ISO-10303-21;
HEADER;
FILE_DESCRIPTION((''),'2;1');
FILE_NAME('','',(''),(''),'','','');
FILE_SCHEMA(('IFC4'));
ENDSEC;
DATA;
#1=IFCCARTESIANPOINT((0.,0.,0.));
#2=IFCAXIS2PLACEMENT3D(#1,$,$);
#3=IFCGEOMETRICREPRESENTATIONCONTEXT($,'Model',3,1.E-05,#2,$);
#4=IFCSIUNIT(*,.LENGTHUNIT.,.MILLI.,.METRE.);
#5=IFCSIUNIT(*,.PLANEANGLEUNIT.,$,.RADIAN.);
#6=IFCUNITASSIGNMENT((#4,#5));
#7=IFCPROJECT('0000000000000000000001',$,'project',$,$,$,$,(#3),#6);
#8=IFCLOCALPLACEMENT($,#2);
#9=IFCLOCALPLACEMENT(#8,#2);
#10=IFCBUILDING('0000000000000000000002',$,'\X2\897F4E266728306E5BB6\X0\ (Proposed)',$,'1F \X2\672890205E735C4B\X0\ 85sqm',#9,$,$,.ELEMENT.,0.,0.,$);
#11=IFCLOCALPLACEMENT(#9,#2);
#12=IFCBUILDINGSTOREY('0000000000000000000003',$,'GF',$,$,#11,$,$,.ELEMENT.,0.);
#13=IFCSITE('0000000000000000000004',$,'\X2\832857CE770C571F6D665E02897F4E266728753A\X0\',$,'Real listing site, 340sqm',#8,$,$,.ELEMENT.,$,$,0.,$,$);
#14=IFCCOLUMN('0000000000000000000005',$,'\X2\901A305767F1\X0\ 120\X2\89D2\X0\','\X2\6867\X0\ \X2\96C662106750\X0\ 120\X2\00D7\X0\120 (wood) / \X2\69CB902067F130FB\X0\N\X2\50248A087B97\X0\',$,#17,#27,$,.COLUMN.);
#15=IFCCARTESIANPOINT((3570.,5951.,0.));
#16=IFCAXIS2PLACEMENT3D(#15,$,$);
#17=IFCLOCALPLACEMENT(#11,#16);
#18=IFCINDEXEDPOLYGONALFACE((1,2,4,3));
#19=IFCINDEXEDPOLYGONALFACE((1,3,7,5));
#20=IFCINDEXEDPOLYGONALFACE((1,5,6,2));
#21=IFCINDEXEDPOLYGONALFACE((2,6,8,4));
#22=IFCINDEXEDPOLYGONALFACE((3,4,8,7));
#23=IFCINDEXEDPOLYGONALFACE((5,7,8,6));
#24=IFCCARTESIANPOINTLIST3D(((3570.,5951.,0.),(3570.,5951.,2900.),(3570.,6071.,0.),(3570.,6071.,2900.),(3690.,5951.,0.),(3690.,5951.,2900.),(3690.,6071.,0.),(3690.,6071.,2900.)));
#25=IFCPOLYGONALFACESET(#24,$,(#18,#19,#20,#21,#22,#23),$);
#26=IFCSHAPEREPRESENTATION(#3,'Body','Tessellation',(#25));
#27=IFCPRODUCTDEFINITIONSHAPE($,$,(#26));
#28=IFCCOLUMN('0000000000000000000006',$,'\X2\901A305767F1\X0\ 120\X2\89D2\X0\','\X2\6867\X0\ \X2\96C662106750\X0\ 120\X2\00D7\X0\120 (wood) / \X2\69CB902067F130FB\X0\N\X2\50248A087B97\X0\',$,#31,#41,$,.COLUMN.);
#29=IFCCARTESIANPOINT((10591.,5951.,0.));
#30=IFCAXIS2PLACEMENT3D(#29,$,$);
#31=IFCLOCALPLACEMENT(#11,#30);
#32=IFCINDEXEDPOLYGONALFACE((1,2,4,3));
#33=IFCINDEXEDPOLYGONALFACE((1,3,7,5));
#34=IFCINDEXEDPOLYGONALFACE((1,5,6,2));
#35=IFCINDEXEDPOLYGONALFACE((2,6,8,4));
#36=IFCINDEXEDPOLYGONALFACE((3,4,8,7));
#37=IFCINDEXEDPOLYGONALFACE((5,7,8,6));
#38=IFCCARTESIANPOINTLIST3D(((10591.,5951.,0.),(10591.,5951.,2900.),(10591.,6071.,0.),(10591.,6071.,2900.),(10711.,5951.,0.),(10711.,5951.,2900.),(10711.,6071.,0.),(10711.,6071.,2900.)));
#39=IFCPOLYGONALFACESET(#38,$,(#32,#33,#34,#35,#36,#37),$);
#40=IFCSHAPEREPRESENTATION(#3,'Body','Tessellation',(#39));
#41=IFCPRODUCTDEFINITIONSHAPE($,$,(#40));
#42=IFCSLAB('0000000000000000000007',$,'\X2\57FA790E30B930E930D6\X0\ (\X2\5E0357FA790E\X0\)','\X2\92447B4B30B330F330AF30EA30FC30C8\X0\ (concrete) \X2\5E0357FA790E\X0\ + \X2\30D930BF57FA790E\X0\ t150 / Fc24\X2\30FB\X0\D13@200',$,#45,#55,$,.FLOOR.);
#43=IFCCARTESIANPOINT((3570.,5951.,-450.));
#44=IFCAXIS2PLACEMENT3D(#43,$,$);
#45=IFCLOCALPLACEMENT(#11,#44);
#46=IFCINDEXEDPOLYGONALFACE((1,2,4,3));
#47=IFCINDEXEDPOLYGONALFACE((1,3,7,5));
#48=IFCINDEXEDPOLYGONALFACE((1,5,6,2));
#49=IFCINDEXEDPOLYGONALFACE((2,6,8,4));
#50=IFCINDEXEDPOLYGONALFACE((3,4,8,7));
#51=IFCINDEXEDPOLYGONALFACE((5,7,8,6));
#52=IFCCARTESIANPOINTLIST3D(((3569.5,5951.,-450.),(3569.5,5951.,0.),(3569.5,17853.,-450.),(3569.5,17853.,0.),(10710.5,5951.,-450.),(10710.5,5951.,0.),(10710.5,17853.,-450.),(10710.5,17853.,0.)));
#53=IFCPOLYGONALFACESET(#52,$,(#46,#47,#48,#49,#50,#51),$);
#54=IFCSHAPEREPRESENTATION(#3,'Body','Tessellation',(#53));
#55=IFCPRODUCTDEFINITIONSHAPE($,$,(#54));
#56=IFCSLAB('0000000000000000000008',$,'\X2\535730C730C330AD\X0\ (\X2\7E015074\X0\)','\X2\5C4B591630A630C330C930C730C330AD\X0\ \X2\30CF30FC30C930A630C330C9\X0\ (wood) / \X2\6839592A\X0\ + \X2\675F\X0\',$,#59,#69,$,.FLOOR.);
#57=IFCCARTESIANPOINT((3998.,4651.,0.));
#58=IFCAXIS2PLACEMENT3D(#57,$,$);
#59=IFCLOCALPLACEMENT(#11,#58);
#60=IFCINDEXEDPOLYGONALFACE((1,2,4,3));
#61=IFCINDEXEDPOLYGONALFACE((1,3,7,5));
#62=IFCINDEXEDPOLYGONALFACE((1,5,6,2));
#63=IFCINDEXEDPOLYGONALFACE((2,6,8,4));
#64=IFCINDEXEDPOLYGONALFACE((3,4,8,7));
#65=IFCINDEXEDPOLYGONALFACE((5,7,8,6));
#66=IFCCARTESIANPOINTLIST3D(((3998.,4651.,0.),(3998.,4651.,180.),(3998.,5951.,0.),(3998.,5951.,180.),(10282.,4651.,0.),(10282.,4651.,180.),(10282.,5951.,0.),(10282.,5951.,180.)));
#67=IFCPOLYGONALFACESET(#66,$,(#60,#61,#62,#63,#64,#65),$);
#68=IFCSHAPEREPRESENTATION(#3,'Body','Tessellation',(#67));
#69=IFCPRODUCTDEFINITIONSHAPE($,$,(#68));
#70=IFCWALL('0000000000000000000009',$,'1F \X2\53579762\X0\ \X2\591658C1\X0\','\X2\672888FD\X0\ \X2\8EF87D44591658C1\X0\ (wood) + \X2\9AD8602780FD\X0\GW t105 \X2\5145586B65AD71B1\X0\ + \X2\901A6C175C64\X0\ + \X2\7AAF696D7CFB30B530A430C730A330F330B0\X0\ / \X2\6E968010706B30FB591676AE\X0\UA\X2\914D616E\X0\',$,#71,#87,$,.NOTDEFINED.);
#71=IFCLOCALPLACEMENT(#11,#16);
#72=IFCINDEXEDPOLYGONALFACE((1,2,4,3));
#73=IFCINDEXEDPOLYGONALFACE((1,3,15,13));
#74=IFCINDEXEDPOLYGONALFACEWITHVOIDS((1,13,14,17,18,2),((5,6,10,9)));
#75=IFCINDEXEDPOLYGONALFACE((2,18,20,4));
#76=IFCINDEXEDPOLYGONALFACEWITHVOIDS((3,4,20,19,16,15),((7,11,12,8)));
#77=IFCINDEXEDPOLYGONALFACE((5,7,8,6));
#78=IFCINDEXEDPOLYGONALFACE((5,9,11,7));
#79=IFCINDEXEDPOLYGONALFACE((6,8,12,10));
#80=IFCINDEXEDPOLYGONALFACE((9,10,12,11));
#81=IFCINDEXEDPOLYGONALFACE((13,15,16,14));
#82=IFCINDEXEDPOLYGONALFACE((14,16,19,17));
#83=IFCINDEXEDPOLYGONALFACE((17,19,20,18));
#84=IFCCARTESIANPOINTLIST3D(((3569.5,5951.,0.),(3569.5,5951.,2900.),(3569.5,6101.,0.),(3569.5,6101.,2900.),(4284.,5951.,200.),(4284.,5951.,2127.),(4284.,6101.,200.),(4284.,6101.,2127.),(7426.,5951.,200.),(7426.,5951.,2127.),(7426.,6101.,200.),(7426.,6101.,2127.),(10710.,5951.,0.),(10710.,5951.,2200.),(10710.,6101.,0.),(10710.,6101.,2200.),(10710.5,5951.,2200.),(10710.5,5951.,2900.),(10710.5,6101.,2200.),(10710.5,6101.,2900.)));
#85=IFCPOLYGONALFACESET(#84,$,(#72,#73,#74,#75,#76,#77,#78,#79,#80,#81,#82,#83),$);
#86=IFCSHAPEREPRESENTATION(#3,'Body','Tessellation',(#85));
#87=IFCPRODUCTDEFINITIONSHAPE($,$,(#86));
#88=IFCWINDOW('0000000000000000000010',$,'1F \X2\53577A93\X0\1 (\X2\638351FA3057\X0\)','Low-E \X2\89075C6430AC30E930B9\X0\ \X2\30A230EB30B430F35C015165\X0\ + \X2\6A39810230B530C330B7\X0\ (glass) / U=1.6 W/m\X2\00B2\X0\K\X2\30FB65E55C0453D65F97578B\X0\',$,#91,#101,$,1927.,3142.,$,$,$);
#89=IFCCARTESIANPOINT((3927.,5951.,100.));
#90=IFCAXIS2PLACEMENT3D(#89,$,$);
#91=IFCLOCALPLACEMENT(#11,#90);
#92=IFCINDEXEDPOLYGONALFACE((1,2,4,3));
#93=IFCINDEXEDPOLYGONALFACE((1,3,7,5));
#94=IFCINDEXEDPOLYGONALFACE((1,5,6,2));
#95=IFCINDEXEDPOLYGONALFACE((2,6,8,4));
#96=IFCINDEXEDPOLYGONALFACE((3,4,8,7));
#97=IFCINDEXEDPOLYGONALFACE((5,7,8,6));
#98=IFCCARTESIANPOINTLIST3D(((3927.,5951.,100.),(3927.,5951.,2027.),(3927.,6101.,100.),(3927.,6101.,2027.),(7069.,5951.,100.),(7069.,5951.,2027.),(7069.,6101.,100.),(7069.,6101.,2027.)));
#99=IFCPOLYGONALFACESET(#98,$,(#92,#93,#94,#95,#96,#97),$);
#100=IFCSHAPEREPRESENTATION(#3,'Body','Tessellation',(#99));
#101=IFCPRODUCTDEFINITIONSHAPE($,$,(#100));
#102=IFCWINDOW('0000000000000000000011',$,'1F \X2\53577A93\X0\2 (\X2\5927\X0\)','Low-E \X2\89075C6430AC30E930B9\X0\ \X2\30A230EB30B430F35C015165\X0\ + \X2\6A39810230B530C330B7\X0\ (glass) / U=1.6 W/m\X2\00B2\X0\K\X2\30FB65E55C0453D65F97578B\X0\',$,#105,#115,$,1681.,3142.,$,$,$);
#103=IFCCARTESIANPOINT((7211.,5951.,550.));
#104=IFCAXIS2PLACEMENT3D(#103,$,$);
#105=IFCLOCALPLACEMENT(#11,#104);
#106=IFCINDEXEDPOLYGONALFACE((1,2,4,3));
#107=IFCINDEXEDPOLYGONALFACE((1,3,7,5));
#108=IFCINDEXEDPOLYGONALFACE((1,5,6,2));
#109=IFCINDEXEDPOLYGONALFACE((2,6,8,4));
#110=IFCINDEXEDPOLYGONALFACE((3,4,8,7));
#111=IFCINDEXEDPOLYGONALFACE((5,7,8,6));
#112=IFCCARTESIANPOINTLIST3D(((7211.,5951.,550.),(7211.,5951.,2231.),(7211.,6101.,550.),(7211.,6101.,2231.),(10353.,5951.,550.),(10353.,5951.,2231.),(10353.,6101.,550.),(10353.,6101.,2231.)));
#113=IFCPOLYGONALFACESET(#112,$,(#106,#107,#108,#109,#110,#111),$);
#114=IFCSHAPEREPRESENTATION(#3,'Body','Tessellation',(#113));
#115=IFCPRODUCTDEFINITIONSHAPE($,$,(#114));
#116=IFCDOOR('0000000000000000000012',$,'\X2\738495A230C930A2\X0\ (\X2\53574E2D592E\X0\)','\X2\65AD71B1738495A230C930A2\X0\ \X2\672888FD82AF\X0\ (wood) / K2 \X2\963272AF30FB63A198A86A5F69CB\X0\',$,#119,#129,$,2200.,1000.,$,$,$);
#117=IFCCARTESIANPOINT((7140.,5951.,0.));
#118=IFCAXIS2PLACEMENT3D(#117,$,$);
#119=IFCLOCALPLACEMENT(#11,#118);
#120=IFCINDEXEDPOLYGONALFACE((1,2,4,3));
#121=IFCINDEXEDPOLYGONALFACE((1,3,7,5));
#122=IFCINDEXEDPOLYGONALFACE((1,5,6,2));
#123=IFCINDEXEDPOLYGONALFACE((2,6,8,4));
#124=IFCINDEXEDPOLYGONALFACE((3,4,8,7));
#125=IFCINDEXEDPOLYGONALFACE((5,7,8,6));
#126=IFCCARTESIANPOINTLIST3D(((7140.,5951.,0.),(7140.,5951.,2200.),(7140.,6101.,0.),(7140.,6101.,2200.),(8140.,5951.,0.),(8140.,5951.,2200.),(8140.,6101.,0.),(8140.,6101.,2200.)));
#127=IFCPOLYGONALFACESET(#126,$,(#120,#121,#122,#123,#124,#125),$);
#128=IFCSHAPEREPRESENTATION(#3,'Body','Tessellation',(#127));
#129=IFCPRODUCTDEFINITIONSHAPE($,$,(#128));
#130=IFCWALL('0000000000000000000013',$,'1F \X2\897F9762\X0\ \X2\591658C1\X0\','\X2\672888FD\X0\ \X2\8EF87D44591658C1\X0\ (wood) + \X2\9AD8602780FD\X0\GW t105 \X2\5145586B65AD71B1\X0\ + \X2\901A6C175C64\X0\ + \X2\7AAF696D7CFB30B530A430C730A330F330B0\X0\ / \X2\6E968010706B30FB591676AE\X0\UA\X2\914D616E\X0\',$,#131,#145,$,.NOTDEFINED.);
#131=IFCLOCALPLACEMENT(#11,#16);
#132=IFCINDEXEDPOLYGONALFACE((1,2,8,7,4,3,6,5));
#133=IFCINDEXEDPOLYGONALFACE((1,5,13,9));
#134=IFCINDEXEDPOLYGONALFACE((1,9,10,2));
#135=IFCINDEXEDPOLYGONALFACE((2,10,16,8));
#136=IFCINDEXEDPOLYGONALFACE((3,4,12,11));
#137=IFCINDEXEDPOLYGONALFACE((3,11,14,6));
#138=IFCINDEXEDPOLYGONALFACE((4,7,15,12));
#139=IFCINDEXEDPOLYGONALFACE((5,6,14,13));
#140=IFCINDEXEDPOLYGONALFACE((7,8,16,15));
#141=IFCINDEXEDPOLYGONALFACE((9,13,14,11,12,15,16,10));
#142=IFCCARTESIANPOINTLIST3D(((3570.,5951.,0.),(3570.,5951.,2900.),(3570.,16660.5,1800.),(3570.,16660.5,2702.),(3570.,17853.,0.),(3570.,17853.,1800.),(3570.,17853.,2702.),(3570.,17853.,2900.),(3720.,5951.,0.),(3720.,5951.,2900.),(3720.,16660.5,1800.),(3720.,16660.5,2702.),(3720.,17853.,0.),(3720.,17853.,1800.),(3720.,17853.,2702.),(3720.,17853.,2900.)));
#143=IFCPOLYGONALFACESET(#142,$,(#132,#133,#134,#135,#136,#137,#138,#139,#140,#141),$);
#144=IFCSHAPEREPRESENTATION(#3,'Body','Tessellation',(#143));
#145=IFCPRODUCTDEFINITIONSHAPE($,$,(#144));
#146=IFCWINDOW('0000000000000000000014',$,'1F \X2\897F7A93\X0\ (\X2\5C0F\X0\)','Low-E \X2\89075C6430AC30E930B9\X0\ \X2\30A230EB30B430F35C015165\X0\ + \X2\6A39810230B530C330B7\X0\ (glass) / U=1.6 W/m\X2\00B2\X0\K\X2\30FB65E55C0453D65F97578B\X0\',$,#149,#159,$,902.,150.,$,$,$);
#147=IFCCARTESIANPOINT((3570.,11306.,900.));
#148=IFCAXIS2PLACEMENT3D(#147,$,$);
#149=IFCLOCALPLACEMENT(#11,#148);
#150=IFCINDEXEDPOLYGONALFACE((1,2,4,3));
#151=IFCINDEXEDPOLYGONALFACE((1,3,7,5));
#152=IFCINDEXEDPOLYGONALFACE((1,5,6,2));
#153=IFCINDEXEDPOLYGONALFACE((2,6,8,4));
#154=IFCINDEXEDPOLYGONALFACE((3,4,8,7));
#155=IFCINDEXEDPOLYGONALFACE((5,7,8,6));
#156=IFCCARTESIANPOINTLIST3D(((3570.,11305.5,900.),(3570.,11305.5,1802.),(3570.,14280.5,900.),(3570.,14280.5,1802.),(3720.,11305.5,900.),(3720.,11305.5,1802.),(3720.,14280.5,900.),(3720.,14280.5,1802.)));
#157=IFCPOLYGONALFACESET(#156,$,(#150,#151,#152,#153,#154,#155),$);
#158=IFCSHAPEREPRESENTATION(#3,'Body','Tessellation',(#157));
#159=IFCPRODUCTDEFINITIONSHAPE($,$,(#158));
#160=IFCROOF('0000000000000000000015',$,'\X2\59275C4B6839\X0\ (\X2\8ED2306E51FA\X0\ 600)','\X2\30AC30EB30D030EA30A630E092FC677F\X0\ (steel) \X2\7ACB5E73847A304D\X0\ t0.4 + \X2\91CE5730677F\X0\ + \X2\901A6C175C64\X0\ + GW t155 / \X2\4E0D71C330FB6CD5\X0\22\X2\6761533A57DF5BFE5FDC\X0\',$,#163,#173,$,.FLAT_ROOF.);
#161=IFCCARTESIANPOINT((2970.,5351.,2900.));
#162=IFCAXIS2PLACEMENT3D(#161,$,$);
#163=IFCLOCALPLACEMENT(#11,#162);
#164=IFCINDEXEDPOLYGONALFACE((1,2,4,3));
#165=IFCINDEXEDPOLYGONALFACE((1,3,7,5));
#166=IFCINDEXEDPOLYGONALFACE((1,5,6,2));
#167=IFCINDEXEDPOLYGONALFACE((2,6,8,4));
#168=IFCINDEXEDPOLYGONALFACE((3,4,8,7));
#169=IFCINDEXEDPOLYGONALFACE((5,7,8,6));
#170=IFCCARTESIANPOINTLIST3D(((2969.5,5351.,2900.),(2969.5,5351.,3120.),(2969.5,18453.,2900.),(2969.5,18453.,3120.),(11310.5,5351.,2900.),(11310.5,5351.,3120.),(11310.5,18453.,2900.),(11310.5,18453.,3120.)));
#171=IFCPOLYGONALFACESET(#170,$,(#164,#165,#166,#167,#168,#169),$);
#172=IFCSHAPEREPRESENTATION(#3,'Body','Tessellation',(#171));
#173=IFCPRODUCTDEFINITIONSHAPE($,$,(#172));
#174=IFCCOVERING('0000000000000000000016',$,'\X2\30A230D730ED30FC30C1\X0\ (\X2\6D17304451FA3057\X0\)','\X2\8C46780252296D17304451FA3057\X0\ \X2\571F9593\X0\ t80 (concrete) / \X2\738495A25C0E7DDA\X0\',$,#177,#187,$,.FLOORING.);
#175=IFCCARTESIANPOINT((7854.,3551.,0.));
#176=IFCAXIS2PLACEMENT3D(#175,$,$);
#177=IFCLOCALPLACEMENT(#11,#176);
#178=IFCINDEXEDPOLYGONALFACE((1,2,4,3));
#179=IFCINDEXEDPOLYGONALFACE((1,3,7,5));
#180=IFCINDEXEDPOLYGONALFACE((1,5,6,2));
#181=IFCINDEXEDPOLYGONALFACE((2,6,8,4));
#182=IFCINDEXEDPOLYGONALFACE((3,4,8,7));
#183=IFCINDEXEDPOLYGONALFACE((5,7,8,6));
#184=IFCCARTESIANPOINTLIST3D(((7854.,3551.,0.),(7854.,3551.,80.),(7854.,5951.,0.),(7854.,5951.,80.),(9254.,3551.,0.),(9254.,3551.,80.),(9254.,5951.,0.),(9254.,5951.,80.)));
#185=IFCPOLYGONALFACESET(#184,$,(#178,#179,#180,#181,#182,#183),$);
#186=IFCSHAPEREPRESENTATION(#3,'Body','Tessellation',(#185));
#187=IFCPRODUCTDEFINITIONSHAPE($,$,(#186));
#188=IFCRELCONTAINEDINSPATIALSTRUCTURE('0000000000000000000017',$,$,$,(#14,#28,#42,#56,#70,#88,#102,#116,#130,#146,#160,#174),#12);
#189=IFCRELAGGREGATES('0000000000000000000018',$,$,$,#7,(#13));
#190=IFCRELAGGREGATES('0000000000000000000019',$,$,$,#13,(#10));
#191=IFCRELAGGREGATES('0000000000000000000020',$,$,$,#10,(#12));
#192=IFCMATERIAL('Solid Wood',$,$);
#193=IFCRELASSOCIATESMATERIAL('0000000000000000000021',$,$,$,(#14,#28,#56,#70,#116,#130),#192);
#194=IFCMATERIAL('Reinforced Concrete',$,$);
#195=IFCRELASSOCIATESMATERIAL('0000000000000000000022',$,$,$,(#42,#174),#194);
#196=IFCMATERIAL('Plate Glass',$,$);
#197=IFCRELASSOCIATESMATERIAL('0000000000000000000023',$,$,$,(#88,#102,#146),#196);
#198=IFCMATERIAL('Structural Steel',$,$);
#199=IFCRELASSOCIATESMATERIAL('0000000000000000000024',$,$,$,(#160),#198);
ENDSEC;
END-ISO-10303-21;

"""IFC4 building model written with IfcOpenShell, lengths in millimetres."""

from ifc_helpers import new_model, si_unit, frame, frame_2d, origin, place, context, project, spatial, rectangle, extrude, material, element, fill, save


model = new_model("IFC4")

# Units and contexts
model_context = context("Model", 3, precision=1e-05, world=origin())
ifc_project = project(units=[si_unit("LENGTHUNIT", "METRE", prefix="MILLI"), si_unit("PLANEANGLEUNIT", "RADIAN")], contexts=[model_context])

# Site, building, storey
site_placement = place(None, origin())
site = spatial("IfcSite", under=ifc_project, at=site_placement, Name="茨城県土浦市西並木町", ObjectType="Real listing site, 340sqm", CompositionType="ELEMENT", RefElevation=0.0)
building_placement = place(site_placement, origin())
building = spatial("IfcBuilding", under=site, at=building_placement, Name="西並木の家 (Proposed)", ObjectType="1F 木造平屋 85sqm", CompositionType="ELEMENT", ElevationOfRefHeight=0.0, ElevationOfTerrain=0.0)
storey_placement = place(building_placement, origin())
storey = spatial("IfcBuildingStorey", under=building, at=storey_placement, Name="GF", CompositionType="ELEMENT", Elevation=0.0)

# Columns
ifc_material_1 = material(Name="Solid Wood")
column_1_placement = place(storey_placement, frame((3570.0, 5951.0, 0.0)))
element("IfcColumn", 1, at=column_1_placement, inside=storey, material=ifc_material_1, Name="通し柱 120角", Description="桧 集成材 120×120 (wood) / 構造柱・N値計算", PredefinedType="COLUMN", context=model_context, shape_type="SweptSolid", body=[
    extrude(rectangle(XDim=120.0, YDim=120.0, at=frame_2d((60.0, 60.0))), frame((3570.0, 5951.0, 0.0)), (0.0, 0.0, 1.0), 2900.0),
])
column_2_placement = place(storey_placement, frame((10591.0, 5951.0, 0.0)))
element("IfcColumn", 2, at=column_2_placement, inside=storey, material=ifc_material_1, Name="通し柱 120角", Description="桧 集成材 120×120 (wood) / 構造柱・N値計算", PredefinedType="COLUMN", context=model_context, shape_type="SweptSolid", body=[
    extrude(rectangle(XDim=120.0, YDim=120.0, at=frame_2d((60.0, 60.0))), frame((10591.0, 5951.0, 0.0)), (0.0, 0.0, 1.0), 2900.0),
])

# Slabs
ifc_material_2 = material(Name="Reinforced Concrete")
slab_1_placement = place(storey_placement, frame((3570.0, 5951.0, -450.0)))
element("IfcSlab", 3, at=slab_1_placement, inside=storey, material=ifc_material_2, Name="基礎スラブ (布基礎)", Description="鉄筋コンクリート (concrete) 布基礎 + ベタ基礎 t150 / Fc24・D13@200", PredefinedType="FLOOR", context=model_context, shape_type="SweptSolid", body=[
    extrude(rectangle(XDim=7141.0, YDim=11902.0, at=frame_2d((3570.0, 5951.0))), frame((3570.0, 5951.0, -450.0)), (0.0, 0.0, 1.0), 450.0),
])
slab_2_placement = place(storey_placement, frame((3998.0, 4651.0, 0.0)))
element("IfcSlab", 4, at=slab_2_placement, inside=storey, material=ifc_material_1, Name="南デッキ (縁側)", Description="屋外ウッドデッキ ハードウッド (wood) / 根太 + 束", PredefinedType="FLOOR", context=model_context, shape_type="SweptSolid", body=[
    extrude(rectangle(XDim=6284.0, YDim=1300.0, at=frame_2d((3142.0, 650.0))), frame((3998.0, 4651.0, 0.0)), (0.0, 0.0, 1.0), 180.0),
])

# Wall, openings, windows, door
wall_1_placement = place(storey_placement, frame((3570.0, 5951.0, 0.0)))
wall_1 = element("IfcWall", 5, at=wall_1_placement, inside=storey, material=ifc_material_1, Name="1F 南面 外壁", Description="木製 軸組外壁 (wood) + 高性能GW t105 充填断熱 + 通気層 + 窯業系サイディング / 準耐火・外皮UA配慮", PredefinedType="NOTDEFINED", context=model_context, shape_type="SweptSolid", body=[
    extrude(rectangle(XDim=7141.0, YDim=150.0, at=frame_2d((3570.0, 75.0))), frame((3570.0, 5951.0, 0.0)), (0.0, 0.0, 1.0), 2900.0),
])
opening_1_placement = place(storey_placement, frame((3927.0, 5951.0, 100.0)))
opening_1 = element("IfcOpeningElement", 6, at=opening_1_placement, cuts=wall_1, PredefinedType="NOTDEFINED", context=model_context, shape_type="SweptSolid", body=[
    extrude(rectangle(XDim=3142.0, YDim=150.0, at=frame_2d((1571.0, 75.0))), frame((3927.0, 5951.0, 100.0)), (0.0, 0.0, 1.0), 1927.0),
])
opening_2_placement = place(storey_placement, frame((7211.0, 5951.0, 550.0)))
opening_2 = element("IfcOpeningElement", 7, at=opening_2_placement, cuts=wall_1, PredefinedType="NOTDEFINED", context=model_context, shape_type="SweptSolid", body=[
    extrude(rectangle(XDim=3142.0, YDim=150.0, at=frame_2d((1571.0, 75.0))), frame((7211.0, 5951.0, 550.0)), (0.0, 0.0, 1.0), 1681.0),
])
opening_3_placement = place(storey_placement, frame((7140.0, 5951.0, 0.0)))
opening_3 = element("IfcOpeningElement", 8, at=opening_3_placement, cuts=wall_1, PredefinedType="NOTDEFINED", context=model_context, shape_type="SweptSolid", body=[
    extrude(rectangle(XDim=1000.0, YDim=150.0, at=frame_2d((500.0, 75.0))), frame((7140.0, 5951.0, 0.0)), (0.0, 0.0, 1.0), 2200.0),
])
ifc_material_3 = material(Name="Plate Glass")
window_1_placement = place(storey_placement, frame((3927.0, 5951.0, 100.0)))
window_1 = element("IfcWindow", 9, at=window_1_placement, inside=storey, material=ifc_material_3, Name="1F 南窓1 (掃出し)", Description="Low-E 複層ガラス アルゴン封入 + 樹脂サッシ (glass) / U=1.6 W/m²K・日射取得型", OverallHeight=1927.0, OverallWidth=3142.0, context=model_context, shape_type="SweptSolid", body=[
    extrude(rectangle(XDim=3142.0, YDim=150.0, at=frame_2d((1571.0, 75.0))), frame((3927.0, 5951.0, 100.0)), (0.0, 0.0, 1.0), 1927.0),
])
fill(opening_1, window_1)
window_2_placement = place(storey_placement, frame((7211.0, 5951.0, 550.0)))
window_2 = element("IfcWindow", 10, at=window_2_placement, inside=storey, material=ifc_material_3, Name="1F 南窓2 (大)", Description="Low-E 複層ガラス アルゴン封入 + 樹脂サッシ (glass) / U=1.6 W/m²K・日射取得型", OverallHeight=1681.0, OverallWidth=3142.0, context=model_context, shape_type="SweptSolid", body=[
    extrude(rectangle(XDim=3142.0, YDim=150.0, at=frame_2d((1571.0, 75.0))), frame((7211.0, 5951.0, 550.0)), (0.0, 0.0, 1.0), 1681.0),
])
fill(opening_2, window_2)
door_placement = place(storey_placement, frame((7140.0, 5951.0, 0.0)))
door = element("IfcDoor", 11, at=door_placement, inside=storey, material=ifc_material_1, Name="玄関ドア (南中央)", Description="断熱玄関ドア 木製芯 (wood) / K2 防犯・採風機構", OverallHeight=2200.0, OverallWidth=1000.0, context=model_context, shape_type="SweptSolid", body=[
    extrude(rectangle(XDim=1000.0, YDim=150.0, at=frame_2d((500.0, 75.0))), frame((7140.0, 5951.0, 0.0)), (0.0, 0.0, 1.0), 2200.0),
])
fill(opening_3, door)

# Wall, opening, window
wall_2_placement = place(storey_placement, frame((3570.0, 5951.0, 0.0)))
wall_2 = element("IfcWall", 12, at=wall_2_placement, inside=storey, material=ifc_material_1, Name="1F 西面 外壁", Description="木製 軸組外壁 (wood) + 高性能GW t105 充填断熱 + 通気層 + 窯業系サイディング / 準耐火・外皮UA配慮", PredefinedType="NOTDEFINED", context=model_context, shape_type="SweptSolid", body=[
    extrude(rectangle(XDim=150.0, YDim=11902.0, at=frame_2d((75.0, 5951.0))), frame((3570.0, 5951.0, 0.0)), (0.0, 0.0, 1.0), 2900.0),
])
opening_4_placement = place(storey_placement, frame((3570.0, 11306.0, 900.0)))
opening_4 = element("IfcOpeningElement", 13, at=opening_4_placement, cuts=wall_2, PredefinedType="NOTDEFINED", context=model_context, shape_type="SweptSolid", body=[
    extrude(rectangle(XDim=150.0, YDim=2975.0, at=frame_2d((75.0, 1487.0))), frame((3570.0, 11306.0, 900.0)), (0.0, 0.0, 1.0), 902.0),
])
window_3_placement = place(storey_placement, frame((3570.0, 11306.0, 900.0)))
window_3 = element("IfcWindow", 14, at=window_3_placement, inside=storey, material=ifc_material_3, Name="1F 西窓 (小)", Description="Low-E 複層ガラス アルゴン封入 + 樹脂サッシ (glass) / U=1.6 W/m²K・日射取得型", OverallHeight=902.0, OverallWidth=150.0, context=model_context, shape_type="SweptSolid", body=[
    extrude(rectangle(XDim=150.0, YDim=2975.0, at=frame_2d((75.0, 1487.0))), frame((3570.0, 11306.0, 900.0)), (0.0, 0.0, 1.0), 902.0),
])
fill(opening_4, window_3)

# Roof
ifc_material_4 = material(Name="Structural Steel")
roof_placement = place(storey_placement, frame((2970.0, 5351.0, 2900.0)))
element("IfcRoof", 15, at=roof_placement, inside=storey, material=ifc_material_4, Name="大屋根 (軒の出 600)", Description="ガルバリウム鋼板 (steel) 立平葺き t0.4 + 野地板 + 通気層 + GW t155 / 不燃・法22条区域対応", PredefinedType="FLAT_ROOF", context=model_context, shape_type="SweptSolid", body=[
    extrude(rectangle(XDim=8341.0, YDim=13102.0, at=frame_2d((4170.0, 6551.0))), frame((2970.0, 5351.0, 2900.0)), (0.0, 0.0, 1.0), 220.0),
])

# Covering
covering_1_placement = place(storey_placement, frame((7854.0, 3551.0, 0.0)))
element("IfcCovering", 16, at=covering_1_placement, inside=storey, material=ifc_material_2, Name="アプローチ (洗い出し)", Description="豆砂利洗い出し 土間 t80 (concrete) / 玄関導線", PredefinedType="FLOORING", context=model_context, shape_type="SweptSolid", body=[
    extrude(rectangle(XDim=1400.0, YDim=2400.0, at=frame_2d((700.0, 1200.0))), frame((7854.0, 3551.0, 0.0)), (0.0, 0.0, 1.0), 80.0),
])

save(model, "model.ifc")
